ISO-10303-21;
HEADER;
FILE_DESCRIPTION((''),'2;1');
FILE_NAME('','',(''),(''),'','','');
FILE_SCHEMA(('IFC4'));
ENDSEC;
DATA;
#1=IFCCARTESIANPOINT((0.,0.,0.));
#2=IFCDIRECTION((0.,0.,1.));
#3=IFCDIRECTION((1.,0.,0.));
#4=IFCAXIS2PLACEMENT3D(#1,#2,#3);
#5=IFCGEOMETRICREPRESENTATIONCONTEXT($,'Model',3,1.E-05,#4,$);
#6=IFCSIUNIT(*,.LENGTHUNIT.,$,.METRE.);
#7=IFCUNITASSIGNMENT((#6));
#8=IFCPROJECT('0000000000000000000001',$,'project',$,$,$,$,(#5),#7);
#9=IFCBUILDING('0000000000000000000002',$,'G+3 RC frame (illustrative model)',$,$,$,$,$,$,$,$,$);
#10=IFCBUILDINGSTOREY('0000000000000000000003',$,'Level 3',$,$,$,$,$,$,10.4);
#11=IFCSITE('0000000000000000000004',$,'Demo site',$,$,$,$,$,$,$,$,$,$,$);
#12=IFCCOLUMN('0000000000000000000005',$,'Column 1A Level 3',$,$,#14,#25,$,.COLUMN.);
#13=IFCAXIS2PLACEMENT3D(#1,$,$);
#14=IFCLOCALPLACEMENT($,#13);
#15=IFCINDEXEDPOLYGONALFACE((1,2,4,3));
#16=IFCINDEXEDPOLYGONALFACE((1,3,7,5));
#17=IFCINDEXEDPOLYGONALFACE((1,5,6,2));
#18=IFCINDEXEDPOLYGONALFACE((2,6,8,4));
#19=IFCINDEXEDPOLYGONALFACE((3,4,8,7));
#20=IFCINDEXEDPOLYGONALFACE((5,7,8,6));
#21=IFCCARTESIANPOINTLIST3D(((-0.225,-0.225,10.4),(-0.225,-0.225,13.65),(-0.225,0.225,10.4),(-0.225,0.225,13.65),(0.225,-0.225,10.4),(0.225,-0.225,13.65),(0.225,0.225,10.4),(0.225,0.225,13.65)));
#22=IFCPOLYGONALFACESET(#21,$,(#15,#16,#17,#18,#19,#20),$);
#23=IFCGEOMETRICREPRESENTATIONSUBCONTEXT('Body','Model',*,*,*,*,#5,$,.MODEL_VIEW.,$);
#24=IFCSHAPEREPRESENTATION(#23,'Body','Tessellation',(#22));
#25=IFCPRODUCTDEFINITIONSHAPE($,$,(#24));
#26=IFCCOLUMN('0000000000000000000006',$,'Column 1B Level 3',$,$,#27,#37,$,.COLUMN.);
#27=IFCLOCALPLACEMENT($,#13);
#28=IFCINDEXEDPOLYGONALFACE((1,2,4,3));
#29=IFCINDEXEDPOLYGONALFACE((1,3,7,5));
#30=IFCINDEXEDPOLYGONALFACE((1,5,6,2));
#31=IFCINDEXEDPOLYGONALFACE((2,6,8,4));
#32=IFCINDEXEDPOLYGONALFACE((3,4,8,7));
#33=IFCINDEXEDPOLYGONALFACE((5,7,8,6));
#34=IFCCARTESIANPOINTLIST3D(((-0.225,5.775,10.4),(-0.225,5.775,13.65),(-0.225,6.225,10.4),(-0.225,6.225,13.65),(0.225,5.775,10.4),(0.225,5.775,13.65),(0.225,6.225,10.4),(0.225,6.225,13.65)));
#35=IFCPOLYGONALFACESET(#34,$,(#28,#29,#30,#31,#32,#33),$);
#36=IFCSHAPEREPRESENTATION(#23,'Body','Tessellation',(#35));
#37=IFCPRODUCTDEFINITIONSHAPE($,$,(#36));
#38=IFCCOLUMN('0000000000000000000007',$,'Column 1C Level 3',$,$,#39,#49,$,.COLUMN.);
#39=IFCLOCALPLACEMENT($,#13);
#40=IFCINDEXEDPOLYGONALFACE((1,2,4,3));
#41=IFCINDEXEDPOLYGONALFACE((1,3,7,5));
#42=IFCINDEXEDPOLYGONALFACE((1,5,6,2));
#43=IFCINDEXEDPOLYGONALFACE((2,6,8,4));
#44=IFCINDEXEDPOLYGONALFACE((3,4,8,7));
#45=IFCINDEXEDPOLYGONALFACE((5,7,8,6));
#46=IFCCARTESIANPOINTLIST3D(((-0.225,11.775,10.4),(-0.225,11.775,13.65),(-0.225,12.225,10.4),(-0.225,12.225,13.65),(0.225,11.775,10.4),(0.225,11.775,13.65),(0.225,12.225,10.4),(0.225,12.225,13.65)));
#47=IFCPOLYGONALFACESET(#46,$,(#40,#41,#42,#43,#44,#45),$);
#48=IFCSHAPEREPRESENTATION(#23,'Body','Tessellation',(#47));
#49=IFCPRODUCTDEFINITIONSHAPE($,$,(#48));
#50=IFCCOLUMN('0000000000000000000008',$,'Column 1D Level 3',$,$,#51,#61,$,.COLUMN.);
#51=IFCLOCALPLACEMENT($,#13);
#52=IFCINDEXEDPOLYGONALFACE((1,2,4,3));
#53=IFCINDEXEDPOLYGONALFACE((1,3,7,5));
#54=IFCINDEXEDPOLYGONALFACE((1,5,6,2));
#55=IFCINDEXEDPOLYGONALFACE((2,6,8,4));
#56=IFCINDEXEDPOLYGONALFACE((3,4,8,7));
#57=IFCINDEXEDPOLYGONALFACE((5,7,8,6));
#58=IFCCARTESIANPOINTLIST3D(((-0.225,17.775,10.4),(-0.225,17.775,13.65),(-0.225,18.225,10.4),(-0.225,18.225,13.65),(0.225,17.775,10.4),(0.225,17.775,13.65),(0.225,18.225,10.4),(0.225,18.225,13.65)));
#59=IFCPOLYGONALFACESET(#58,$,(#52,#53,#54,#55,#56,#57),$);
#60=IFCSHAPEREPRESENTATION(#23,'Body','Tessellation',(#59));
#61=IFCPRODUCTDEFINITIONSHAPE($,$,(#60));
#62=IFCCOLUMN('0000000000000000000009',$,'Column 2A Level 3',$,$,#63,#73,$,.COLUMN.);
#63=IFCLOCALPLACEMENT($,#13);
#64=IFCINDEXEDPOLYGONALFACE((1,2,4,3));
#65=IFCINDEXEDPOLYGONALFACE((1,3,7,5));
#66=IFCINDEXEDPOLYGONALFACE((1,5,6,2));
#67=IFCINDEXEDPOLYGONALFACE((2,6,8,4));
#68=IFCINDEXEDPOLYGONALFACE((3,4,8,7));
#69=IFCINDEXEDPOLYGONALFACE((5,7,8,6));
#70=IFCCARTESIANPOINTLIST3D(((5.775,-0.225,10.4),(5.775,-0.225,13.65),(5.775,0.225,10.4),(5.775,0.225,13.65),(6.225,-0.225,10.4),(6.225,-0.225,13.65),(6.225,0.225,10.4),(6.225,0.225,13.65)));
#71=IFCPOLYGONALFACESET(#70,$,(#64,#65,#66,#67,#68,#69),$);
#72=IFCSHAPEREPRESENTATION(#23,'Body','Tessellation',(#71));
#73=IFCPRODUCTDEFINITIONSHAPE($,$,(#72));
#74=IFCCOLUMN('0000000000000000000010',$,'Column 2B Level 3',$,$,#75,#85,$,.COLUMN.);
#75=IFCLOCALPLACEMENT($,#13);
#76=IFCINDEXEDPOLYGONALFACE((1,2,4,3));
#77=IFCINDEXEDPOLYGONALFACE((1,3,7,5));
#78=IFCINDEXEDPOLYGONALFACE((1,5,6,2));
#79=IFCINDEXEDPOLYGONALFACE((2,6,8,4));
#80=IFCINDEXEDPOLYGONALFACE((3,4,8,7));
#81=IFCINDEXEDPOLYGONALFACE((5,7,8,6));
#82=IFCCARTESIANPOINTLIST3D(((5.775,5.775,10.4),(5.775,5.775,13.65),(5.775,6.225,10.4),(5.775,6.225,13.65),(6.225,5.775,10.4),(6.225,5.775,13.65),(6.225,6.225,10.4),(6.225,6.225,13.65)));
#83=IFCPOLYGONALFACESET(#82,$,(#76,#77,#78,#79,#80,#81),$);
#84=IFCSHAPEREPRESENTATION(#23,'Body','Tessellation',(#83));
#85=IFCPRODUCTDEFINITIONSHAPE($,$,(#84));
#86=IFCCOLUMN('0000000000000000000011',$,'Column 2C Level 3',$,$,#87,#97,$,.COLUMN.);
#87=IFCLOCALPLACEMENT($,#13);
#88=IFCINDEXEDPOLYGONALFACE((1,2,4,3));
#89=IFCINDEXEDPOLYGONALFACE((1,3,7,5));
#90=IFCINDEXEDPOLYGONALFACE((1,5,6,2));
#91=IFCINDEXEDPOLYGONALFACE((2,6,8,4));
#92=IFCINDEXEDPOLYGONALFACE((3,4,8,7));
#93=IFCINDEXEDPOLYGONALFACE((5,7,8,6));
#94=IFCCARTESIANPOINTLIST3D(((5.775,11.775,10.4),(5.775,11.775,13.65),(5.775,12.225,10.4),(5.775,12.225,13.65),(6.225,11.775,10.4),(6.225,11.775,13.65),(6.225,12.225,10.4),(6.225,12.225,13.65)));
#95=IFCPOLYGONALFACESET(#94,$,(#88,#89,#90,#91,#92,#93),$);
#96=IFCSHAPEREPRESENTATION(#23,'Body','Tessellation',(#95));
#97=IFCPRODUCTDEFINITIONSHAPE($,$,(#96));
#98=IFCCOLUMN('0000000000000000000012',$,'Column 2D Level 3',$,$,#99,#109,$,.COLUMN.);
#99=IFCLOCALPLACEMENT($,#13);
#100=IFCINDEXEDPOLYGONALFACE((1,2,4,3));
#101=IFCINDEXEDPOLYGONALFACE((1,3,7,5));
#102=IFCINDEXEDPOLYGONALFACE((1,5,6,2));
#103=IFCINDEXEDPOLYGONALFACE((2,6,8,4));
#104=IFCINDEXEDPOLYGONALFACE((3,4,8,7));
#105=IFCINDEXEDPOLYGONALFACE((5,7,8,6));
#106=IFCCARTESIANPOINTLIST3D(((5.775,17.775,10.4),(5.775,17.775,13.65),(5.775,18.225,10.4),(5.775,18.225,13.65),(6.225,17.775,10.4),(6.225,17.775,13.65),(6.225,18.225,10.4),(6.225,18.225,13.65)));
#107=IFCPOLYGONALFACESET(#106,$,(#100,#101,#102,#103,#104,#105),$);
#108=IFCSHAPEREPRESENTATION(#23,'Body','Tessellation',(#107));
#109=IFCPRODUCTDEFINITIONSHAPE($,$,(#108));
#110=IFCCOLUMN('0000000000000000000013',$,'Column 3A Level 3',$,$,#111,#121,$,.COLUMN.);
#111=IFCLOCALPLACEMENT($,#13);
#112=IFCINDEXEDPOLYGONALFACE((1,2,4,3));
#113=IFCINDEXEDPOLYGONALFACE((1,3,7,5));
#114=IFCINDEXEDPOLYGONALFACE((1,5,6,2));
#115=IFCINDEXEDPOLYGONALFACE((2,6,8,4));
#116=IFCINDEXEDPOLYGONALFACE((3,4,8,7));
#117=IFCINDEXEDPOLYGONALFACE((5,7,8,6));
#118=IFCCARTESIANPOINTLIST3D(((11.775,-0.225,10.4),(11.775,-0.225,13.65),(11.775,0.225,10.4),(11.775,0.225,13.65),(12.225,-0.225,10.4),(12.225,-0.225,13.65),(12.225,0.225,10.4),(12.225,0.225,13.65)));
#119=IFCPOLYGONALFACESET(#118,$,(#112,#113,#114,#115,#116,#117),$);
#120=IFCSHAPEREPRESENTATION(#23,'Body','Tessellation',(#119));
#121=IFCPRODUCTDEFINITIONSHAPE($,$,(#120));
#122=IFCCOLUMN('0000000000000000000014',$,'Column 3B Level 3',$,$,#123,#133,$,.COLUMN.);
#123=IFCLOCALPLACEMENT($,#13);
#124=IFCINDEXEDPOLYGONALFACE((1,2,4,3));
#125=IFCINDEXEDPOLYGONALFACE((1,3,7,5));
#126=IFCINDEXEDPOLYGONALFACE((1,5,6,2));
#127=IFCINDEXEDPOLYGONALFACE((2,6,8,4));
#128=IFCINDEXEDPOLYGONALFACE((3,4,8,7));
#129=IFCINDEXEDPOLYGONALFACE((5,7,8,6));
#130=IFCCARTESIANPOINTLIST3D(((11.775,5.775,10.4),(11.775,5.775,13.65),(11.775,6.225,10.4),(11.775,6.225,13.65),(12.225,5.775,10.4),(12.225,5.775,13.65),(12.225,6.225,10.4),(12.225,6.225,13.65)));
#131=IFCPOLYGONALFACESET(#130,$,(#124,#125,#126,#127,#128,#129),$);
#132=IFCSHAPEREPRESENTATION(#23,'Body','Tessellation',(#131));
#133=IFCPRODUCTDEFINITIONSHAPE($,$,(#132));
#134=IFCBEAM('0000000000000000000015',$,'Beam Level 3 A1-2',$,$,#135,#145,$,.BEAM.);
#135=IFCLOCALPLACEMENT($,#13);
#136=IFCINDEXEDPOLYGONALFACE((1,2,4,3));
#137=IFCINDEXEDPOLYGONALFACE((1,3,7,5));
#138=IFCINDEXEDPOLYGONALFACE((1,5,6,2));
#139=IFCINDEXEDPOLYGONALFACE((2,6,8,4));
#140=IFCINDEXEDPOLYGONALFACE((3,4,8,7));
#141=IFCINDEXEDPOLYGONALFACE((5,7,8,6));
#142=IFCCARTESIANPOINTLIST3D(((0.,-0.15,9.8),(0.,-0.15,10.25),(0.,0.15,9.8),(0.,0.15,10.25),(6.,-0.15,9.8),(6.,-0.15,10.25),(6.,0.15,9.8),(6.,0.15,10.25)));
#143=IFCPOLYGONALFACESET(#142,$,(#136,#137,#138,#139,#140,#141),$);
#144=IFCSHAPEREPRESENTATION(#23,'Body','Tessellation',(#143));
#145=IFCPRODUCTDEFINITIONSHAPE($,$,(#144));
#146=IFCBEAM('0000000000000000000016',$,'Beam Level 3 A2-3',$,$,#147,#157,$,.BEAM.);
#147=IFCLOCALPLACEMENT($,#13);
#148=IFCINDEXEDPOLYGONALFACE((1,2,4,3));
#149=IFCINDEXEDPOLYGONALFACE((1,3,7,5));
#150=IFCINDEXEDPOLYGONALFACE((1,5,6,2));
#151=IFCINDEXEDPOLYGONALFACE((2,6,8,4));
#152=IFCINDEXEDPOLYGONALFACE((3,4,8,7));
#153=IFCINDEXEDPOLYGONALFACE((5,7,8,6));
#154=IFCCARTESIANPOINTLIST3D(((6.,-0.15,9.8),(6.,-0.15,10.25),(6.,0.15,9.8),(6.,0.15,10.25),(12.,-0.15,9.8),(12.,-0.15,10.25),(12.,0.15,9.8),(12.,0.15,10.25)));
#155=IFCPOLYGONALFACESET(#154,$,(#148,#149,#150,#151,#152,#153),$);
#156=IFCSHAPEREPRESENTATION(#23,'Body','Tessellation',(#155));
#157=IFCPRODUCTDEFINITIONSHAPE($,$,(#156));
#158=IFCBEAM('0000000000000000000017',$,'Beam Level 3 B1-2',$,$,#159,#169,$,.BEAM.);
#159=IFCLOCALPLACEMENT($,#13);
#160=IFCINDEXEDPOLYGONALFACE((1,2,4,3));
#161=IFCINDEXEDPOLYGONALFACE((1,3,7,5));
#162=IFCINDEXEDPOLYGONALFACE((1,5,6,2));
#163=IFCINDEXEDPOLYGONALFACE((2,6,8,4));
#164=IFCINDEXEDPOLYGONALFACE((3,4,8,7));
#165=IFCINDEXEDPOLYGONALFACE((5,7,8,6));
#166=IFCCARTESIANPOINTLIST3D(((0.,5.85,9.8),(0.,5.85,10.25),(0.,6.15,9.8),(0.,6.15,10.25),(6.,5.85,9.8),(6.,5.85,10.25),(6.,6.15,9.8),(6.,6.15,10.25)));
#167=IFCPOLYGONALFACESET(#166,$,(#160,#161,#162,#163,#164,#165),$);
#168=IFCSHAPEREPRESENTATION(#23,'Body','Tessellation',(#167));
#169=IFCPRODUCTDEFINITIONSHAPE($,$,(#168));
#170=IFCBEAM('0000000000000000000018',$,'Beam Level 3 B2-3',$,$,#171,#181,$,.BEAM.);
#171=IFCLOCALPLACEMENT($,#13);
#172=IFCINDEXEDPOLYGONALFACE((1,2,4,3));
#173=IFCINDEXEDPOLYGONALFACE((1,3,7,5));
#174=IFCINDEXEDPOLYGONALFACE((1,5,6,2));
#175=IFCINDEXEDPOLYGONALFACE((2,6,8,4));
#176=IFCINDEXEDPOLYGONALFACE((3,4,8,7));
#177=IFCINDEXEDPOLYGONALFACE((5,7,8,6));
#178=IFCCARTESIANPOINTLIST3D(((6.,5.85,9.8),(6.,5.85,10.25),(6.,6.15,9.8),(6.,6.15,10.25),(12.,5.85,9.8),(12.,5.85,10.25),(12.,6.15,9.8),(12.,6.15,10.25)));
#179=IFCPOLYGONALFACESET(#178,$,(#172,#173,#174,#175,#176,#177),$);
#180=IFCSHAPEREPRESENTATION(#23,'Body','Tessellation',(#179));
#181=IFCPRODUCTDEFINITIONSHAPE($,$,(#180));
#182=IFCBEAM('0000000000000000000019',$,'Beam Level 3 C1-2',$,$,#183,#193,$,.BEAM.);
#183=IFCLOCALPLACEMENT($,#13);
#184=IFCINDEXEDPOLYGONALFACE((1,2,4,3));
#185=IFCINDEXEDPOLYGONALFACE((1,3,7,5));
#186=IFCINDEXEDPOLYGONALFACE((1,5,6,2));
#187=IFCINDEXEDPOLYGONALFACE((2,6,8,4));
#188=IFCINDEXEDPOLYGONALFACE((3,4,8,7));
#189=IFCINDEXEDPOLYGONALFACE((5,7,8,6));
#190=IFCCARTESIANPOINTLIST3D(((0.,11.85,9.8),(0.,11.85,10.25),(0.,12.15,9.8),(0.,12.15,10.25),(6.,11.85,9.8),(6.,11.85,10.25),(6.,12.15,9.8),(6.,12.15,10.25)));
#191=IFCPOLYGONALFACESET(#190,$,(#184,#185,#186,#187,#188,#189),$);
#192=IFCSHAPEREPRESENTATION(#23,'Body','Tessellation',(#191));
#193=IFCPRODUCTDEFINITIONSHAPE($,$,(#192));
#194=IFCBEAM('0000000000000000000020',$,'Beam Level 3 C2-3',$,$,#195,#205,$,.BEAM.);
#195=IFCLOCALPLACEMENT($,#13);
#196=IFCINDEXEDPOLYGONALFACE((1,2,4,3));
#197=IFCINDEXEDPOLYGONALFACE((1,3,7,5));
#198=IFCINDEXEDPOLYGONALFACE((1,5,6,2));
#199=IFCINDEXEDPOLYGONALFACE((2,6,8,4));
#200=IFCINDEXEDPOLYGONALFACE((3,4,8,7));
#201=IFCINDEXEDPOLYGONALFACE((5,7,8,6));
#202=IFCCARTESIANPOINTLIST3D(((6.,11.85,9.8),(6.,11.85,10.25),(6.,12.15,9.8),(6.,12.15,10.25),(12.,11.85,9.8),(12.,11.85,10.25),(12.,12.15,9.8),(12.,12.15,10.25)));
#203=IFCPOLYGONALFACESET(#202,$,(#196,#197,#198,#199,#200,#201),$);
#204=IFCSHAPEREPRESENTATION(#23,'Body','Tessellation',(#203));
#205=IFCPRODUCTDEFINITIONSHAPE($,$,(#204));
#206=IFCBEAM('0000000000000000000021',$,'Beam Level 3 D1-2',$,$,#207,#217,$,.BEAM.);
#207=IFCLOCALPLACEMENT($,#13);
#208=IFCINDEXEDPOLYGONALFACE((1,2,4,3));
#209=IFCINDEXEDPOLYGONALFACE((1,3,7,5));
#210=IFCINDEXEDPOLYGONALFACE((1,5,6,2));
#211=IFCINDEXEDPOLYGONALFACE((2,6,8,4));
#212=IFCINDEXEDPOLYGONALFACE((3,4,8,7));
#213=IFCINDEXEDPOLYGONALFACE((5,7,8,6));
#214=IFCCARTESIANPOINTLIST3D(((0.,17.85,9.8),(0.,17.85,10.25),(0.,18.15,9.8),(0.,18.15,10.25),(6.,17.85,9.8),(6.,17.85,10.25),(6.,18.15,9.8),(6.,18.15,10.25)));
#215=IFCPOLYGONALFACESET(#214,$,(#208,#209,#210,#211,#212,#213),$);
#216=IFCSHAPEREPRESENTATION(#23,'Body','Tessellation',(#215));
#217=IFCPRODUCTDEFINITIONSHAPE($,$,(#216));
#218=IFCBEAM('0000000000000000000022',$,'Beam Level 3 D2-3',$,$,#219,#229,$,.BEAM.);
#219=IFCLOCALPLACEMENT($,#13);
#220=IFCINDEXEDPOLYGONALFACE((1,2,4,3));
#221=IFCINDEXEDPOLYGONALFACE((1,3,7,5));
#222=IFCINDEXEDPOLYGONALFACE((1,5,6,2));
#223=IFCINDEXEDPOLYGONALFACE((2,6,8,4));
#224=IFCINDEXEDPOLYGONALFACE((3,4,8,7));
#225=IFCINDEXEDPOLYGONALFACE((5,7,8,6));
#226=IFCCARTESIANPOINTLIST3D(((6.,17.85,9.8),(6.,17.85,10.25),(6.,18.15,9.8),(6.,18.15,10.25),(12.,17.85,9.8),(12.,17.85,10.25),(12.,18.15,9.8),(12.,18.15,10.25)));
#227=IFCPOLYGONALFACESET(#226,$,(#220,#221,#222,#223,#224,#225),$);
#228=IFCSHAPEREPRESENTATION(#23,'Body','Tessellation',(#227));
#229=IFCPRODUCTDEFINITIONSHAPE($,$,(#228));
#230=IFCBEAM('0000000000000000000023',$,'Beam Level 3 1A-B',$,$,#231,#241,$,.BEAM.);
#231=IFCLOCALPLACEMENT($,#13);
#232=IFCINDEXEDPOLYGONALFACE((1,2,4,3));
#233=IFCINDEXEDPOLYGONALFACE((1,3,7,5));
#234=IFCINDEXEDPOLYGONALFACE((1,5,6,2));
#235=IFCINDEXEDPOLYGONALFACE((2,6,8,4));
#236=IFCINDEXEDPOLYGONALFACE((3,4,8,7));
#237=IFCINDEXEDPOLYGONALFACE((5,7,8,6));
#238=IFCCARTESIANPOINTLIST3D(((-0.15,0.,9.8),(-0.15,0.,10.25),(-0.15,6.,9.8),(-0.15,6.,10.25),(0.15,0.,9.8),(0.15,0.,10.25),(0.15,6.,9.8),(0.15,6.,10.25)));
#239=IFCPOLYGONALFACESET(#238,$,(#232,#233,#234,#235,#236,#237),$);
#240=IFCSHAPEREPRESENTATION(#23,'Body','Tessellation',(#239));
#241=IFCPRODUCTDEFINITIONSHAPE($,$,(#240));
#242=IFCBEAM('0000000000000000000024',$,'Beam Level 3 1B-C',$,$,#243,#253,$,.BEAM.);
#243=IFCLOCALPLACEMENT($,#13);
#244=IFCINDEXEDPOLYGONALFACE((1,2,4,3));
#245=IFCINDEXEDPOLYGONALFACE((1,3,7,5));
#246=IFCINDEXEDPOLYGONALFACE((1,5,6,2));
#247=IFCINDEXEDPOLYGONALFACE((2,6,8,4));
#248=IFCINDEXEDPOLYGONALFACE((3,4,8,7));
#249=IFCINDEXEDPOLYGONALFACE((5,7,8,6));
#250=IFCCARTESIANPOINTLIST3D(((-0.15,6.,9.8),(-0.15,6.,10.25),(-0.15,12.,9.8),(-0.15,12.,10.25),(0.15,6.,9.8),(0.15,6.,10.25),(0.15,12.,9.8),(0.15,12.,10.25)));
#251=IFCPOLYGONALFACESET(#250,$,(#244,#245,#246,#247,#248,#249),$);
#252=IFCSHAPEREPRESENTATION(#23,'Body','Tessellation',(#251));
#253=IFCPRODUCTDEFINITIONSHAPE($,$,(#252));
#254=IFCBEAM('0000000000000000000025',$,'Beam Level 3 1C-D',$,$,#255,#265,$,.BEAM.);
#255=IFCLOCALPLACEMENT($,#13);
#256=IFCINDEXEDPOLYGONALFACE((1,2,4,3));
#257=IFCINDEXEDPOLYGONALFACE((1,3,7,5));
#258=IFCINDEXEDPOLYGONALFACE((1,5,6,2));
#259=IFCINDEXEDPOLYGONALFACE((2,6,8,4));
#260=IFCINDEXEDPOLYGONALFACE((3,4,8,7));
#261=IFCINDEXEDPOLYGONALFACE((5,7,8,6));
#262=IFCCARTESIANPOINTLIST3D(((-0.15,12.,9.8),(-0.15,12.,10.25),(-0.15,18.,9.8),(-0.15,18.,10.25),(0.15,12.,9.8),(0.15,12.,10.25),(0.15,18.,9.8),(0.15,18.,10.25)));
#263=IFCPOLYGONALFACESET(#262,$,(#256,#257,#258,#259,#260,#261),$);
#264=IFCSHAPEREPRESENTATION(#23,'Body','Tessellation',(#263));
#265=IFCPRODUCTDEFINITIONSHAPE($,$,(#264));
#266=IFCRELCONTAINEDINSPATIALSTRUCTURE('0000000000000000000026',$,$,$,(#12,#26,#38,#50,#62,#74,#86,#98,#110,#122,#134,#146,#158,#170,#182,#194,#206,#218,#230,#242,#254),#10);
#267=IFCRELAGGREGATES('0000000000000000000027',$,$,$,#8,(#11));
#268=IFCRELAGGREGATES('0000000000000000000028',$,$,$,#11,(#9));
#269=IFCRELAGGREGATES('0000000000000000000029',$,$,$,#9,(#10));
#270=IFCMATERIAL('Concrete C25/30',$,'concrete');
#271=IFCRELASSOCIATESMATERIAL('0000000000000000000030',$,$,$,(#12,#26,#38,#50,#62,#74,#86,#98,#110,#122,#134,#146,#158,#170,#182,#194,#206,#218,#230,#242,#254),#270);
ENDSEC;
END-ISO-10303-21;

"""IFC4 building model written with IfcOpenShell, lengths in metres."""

from ifc_helpers import new_model, si_unit, frame, frame_2d, origin, origin_with_axes, place, context, subcontext, project, spatial, rectangle, extrude, material, element, save


model = new_model("IFC4")

# Units and contexts
model_context = context("Model", 3, precision=1e-05, world=origin_with_axes())
body_context = subcontext(model_context, "Body", "Model", "MODEL_VIEW")
ifc_project = project(units=[si_unit("LENGTHUNIT", "METRE")], contexts=[model_context])

# Site, building, storey
site = spatial("IfcSite", under=ifc_project, Name="Demo site")
building = spatial("IfcBuilding", under=site, Name="G+3 RC frame (illustrative model)")
storey = spatial("IfcBuildingStorey", under=building, Name="Level 3", Elevation=10.4)

# Columns
ifc_material_1 = material(Name="Concrete C25/30", Category="concrete")
for number, where, z_axis, x_axis, name in (
    (1, (-0.225, -0.225, 10.4), (0.0, 0.0, 1.0), (1.0, 0.0, 0.0), "Column 1A Level 3"),
    (2, (-0.225, 5.775, 10.4), (0.0, 0.0, 1.0), (1.0, 0.0, 0.0), "Column 1B Level 3"),
    (3, (-0.225, 11.775, 10.4), (0.0, 0.0, 1.0), (1.0, 0.0, 0.0), "Column 1C Level 3"),
    (4, (-0.225, 17.775, 10.4), (0.0, 0.0, 1.0), (1.0, 0.0, 0.0), "Column 1D Level 3"),
    (5, (5.775, -0.225, 10.4), (0.0, 0.0, 1.0), (1.0, 0.0, 0.0), "Column 2A Level 3"),
    (6, (5.775, 5.775, 10.4), (0.0, 0.0, 1.0), (1.0, 0.0, 0.0), "Column 2B Level 3"),
    (7, (5.775, 11.775, 10.4), (0.0, 0.0, 1.0), (1.0, 0.0, 0.0), "Column 2C Level 3"),
    (8, (5.775, 17.775, 10.4), (0.0, 0.0, 1.0), (1.0, 0.0, 0.0), "Column 2D Level 3"),
    (9, (11.775, -0.225, 10.4), (0.0, 0.0, 1.0), (1.0, 0.0, 0.0), "Column 3A Level 3"),
    (10, (11.775, 5.775, 10.4), (0.0, 0.0, 1.0), (1.0, 0.0, 0.0), "Column 3B Level 3"),
):
    element("IfcColumn", number, at=place(None, frame(where, z_axis=z_axis, x_axis=x_axis)), inside=storey, material=ifc_material_1, Name=name, PredefinedType="COLUMN", context=body_context, shape_type="SweptSolid", body=[
        extrude(rectangle(XDim=0.45, YDim=0.45, at=frame_2d((0.225, 0.225))), origin(), (0.0, 0.0, 1.0), 3.25),
    ])

# Beams
for number, where, z_axis, x_axis, name in (
    (11, (0.0, -0.15, 9.8), (0.0, 0.0, 1.0), (1.0, 0.0, 0.0), "Beam Level 3 A1-2"),
    (12, (6.0, -0.15, 9.8), (0.0, 0.0, 1.0), (1.0, 0.0, 0.0), "Beam Level 3 A2-3"),
    (13, (0.0, 5.85, 9.8), (0.0, 0.0, 1.0), (1.0, 0.0, 0.0), "Beam Level 3 B1-2"),
    (14, (6.0, 5.85, 9.8), (0.0, 0.0, 1.0), (1.0, 0.0, 0.0), "Beam Level 3 B2-3"),
    (15, (0.0, 11.85, 9.8), (0.0, 0.0, 1.0), (1.0, 0.0, 0.0), "Beam Level 3 C1-2"),
    (16, (6.0, 11.85, 9.8), (0.0, 0.0, 1.0), (1.0, 0.0, 0.0), "Beam Level 3 C2-3"),
    (17, (0.0, 17.85, 9.8), (0.0, 0.0, 1.0), (1.0, 0.0, 0.0), "Beam Level 3 D1-2"),
    (18, (6.0, 17.85, 9.8), (0.0, 0.0, 1.0), (1.0, 0.0, 0.0), "Beam Level 3 D2-3"),
):
    element("IfcBeam", number, at=place(None, frame(where, z_axis=z_axis, x_axis=x_axis)), inside=storey, material=ifc_material_1, Name=name, PredefinedType="BEAM", context=body_context, shape_type="SweptSolid", body=[
        extrude(rectangle(XDim=6.0, YDim=0.3, at=frame_2d((3.0, 0.15))), origin(), (0.0, 0.0, 1.0), 0.45),
    ])
for number, where, z_axis, x_axis, name in (
    (19, (-0.15, 0.0, 9.8), (0.0, 0.0, 1.0), (1.0, 0.0, 0.0), "Beam Level 3 1A-B"),
    (20, (-0.15, 6.0, 9.8), (0.0, 0.0, 1.0), (1.0, 0.0, 0.0), "Beam Level 3 1B-C"),
    (21, (-0.15, 12.0, 9.8), (0.0, 0.0, 1.0), (1.0, 0.0, 0.0), "Beam Level 3 1C-D"),
):
    element("IfcBeam", number, at=place(None, frame(where, z_axis=z_axis, x_axis=x_axis)), inside=storey, material=ifc_material_1, Name=name, PredefinedType="BEAM", context=body_context, shape_type="SweptSolid", body=[
        extrude(rectangle(XDim=0.3, YDim=6.0, at=frame_2d((0.15, 3.0))), origin(), (0.0, 0.0, 1.0), 0.45),
    ])

save(model, "model.ifc")
